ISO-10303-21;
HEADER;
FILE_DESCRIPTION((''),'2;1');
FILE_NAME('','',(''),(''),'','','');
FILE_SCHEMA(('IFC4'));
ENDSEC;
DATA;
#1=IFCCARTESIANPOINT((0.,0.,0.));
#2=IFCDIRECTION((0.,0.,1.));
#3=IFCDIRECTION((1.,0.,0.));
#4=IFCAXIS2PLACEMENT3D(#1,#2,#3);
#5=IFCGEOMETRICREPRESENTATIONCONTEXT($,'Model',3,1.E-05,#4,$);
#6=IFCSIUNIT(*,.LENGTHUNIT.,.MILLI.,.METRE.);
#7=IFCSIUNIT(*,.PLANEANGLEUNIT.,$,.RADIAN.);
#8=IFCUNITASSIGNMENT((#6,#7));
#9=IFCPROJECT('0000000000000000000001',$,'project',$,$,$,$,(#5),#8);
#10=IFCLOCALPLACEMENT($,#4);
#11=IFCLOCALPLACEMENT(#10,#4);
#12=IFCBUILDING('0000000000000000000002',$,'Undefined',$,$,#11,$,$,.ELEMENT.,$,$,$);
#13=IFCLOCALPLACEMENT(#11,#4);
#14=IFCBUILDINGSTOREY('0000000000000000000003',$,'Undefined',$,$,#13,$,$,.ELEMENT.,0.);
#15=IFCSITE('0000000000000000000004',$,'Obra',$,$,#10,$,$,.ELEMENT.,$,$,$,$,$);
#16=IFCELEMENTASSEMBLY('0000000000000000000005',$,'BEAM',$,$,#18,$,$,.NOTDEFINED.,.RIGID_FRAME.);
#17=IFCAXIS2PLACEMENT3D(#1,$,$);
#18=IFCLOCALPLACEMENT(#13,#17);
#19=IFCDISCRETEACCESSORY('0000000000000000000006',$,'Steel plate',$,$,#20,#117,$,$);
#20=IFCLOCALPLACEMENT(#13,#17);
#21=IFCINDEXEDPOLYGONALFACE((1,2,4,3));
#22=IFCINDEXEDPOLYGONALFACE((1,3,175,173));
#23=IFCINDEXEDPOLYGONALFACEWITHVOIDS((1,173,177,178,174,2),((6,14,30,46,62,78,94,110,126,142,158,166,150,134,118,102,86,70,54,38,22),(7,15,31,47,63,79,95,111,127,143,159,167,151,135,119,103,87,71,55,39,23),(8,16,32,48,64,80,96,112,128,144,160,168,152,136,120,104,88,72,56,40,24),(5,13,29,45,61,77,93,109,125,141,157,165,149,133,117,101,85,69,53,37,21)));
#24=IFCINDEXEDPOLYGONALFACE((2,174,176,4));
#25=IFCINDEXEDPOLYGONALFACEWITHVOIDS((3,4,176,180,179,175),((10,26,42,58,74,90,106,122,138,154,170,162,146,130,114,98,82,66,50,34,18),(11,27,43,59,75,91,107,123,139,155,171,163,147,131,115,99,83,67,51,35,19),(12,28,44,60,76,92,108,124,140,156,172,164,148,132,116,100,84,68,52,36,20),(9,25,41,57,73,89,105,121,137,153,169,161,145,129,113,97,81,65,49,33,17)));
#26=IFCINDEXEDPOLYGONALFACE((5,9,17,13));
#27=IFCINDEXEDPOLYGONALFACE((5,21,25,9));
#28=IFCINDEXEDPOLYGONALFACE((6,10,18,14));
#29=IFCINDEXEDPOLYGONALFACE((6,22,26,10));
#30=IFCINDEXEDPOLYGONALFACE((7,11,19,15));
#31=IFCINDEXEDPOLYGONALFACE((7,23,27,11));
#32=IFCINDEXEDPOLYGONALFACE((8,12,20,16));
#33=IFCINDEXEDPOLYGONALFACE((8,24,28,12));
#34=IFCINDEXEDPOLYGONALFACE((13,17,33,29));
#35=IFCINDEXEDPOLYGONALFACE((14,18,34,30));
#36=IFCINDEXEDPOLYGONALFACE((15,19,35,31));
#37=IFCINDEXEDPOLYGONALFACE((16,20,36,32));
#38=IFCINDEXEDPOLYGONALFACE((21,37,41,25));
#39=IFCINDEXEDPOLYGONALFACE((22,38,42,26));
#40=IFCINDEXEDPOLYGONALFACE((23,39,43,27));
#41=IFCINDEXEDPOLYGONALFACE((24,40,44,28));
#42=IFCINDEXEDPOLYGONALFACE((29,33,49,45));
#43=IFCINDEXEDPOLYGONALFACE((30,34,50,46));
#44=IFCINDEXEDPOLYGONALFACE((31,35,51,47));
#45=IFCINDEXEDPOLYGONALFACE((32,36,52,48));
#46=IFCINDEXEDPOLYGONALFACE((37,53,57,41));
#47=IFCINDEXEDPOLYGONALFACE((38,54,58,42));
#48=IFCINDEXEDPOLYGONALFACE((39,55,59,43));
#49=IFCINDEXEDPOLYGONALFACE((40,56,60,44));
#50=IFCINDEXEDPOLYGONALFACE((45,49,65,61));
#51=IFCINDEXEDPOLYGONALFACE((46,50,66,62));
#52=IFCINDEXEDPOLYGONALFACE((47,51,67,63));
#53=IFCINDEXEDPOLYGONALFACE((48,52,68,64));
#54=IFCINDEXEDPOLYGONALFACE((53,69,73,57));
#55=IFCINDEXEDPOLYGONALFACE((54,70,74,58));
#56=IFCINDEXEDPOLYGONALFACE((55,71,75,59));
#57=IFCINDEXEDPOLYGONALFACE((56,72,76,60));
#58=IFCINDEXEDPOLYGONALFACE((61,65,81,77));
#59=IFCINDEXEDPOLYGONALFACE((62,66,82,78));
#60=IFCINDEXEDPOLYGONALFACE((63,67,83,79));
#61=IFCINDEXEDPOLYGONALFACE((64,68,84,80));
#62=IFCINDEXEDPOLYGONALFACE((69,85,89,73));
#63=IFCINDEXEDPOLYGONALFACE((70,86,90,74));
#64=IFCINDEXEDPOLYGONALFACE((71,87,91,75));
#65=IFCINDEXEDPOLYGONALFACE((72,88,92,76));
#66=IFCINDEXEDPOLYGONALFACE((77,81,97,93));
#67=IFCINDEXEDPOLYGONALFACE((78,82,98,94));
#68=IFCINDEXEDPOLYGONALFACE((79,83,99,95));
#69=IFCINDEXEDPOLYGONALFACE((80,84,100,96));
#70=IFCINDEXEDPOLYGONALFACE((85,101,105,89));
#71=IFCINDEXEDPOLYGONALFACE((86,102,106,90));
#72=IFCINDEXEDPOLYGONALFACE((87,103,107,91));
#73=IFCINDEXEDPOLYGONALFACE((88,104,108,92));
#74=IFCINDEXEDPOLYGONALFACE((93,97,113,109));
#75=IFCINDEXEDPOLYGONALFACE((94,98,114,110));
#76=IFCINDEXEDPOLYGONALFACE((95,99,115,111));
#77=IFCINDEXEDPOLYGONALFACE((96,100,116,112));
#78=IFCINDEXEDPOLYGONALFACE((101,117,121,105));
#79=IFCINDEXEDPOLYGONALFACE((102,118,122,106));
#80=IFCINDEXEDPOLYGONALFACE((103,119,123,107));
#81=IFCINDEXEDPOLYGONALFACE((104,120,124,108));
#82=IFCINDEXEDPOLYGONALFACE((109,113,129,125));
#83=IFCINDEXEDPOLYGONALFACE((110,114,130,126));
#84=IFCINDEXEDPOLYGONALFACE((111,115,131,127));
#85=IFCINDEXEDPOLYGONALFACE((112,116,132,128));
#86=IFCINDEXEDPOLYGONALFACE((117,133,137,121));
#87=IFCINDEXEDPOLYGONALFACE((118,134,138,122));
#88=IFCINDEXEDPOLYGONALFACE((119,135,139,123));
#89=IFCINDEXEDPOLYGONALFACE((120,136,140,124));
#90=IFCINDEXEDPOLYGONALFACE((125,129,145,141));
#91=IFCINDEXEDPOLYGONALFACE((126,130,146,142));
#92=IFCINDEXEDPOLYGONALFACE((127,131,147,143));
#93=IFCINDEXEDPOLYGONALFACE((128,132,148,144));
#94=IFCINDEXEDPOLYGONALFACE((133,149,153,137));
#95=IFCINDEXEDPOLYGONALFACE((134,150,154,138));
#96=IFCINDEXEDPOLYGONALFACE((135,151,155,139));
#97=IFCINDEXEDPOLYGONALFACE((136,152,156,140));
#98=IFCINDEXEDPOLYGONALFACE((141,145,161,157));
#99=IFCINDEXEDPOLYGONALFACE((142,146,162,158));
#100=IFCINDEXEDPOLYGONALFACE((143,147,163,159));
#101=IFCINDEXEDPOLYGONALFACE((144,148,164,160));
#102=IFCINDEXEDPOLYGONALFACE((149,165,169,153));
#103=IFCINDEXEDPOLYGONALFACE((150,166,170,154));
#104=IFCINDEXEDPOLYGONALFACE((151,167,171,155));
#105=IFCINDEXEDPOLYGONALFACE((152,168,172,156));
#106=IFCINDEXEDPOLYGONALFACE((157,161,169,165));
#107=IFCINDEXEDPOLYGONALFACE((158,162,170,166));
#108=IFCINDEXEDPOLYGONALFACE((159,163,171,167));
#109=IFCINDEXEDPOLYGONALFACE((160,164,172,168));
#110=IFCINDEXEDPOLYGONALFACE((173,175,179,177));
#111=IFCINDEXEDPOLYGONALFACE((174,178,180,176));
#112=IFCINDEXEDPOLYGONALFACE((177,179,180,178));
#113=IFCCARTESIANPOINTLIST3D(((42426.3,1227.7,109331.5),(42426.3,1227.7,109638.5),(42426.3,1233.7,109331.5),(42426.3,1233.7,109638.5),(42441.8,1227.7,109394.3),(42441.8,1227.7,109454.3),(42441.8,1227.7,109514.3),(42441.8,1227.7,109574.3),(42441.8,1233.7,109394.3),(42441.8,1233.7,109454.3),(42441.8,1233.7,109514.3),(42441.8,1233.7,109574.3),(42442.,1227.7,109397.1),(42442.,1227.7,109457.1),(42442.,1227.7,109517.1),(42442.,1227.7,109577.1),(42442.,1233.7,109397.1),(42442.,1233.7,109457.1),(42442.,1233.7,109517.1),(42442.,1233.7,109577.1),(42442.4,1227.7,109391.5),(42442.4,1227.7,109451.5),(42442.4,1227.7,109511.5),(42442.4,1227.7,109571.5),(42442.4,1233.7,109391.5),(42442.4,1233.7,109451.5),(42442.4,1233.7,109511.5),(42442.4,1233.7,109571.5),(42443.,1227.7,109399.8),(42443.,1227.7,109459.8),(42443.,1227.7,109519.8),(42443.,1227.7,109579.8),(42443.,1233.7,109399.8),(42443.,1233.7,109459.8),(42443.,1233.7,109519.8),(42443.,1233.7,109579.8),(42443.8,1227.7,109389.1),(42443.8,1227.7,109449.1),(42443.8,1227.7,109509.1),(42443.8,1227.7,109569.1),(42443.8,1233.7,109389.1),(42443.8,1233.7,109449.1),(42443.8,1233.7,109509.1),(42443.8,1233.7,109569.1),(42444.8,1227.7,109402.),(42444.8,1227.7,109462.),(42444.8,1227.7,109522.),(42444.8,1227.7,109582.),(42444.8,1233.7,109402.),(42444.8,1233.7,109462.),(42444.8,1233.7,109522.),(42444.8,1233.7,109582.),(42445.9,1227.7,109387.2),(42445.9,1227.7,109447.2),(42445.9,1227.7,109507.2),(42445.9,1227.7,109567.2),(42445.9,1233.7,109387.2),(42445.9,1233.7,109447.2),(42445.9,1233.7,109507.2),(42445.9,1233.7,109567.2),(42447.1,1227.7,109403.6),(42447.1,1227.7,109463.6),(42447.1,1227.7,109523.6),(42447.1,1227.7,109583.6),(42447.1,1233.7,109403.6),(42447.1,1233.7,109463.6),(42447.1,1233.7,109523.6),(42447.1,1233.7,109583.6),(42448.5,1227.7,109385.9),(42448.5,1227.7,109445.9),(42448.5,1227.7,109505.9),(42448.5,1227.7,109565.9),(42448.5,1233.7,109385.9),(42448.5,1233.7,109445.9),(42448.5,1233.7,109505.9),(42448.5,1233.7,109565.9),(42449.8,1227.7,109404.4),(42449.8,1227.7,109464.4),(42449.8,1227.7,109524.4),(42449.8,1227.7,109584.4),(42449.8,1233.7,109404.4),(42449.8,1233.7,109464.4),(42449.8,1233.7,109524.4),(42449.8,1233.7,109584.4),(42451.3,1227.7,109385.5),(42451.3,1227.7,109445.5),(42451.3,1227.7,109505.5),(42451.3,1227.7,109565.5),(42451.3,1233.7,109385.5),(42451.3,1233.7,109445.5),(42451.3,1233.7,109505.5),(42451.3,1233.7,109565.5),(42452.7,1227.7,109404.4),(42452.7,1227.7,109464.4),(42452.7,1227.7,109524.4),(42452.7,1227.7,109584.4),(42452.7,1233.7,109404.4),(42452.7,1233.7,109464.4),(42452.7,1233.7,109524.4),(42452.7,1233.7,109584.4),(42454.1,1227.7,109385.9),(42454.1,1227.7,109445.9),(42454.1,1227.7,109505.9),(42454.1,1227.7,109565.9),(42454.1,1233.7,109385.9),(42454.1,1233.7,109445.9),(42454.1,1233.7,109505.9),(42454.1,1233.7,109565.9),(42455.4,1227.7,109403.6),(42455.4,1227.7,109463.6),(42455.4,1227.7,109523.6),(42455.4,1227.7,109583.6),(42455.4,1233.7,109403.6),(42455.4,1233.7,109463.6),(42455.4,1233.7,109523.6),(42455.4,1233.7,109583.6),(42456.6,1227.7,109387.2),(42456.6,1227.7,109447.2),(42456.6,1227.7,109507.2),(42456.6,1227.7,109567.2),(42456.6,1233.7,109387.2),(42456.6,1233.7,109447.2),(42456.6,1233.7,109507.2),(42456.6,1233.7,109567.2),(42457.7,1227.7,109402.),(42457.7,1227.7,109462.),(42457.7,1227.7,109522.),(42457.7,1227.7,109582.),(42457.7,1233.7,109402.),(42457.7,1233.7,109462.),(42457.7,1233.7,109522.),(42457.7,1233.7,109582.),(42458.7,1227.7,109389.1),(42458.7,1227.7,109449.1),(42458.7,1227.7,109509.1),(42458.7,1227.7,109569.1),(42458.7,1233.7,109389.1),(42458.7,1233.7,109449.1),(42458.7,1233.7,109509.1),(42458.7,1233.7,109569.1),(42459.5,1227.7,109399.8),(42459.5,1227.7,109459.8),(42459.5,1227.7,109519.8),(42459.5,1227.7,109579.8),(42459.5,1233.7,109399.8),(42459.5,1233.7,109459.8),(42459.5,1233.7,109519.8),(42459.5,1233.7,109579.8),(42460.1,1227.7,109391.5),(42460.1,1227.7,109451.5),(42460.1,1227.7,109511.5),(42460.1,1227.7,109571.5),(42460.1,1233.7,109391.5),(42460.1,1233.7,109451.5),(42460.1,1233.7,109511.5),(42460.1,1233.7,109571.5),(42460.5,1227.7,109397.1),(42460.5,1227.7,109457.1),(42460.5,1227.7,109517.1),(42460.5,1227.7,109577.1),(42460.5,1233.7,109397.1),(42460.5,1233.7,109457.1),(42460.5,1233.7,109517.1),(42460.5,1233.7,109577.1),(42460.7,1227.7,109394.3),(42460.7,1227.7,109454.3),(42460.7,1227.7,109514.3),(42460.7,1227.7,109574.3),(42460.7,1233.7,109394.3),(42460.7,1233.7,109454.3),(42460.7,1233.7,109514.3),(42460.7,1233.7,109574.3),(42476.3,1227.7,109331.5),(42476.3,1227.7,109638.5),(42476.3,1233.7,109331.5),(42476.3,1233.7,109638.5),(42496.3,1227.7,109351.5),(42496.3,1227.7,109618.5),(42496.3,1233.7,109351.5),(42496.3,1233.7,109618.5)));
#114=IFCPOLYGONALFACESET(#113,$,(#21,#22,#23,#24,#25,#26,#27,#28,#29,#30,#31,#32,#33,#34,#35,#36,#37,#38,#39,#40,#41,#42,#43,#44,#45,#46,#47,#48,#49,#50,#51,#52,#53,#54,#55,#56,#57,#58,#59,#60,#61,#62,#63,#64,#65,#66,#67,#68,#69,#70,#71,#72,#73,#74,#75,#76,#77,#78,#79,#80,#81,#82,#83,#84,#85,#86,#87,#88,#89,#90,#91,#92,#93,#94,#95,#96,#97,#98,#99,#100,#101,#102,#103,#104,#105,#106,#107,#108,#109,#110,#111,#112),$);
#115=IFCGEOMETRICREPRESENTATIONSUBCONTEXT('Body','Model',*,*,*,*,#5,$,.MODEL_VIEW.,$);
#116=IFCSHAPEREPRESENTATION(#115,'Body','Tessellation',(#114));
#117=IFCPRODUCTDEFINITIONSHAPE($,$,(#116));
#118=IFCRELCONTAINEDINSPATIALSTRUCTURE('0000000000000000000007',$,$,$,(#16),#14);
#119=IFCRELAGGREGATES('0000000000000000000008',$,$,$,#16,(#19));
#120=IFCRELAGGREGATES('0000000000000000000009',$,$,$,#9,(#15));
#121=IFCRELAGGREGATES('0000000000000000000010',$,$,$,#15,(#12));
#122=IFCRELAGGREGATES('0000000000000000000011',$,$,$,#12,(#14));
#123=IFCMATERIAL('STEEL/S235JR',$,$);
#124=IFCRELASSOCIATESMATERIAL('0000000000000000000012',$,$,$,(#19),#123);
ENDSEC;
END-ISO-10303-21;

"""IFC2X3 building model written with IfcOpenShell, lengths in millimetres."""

from ifc_helpers import new_model, si_unit, frame, origin_with_axes, origin_2d_with_axis, place, context, subcontext, project, spatial, polyline, circle, outline, extrude, source, transform, mapped, material, element, aggregate, save


model = new_model("IFC2X3")

# Units and contexts
model_context = context("Model", 3, precision=1e-05, world=origin_with_axes())
body_context = subcontext(model_context, "Body", "Model", "MODEL_VIEW")
ifc_project = project(units=[si_unit("LENGTHUNIT", "METRE", prefix="MILLI"), si_unit("PLANEANGLEUNIT", "RADIAN")], contexts=[model_context])

# Site, building, storey
site_placement = place(None, origin_with_axes())
site = spatial("IfcSite", under=ifc_project, at=site_placement, Name="Obra", CompositionType="ELEMENT")
building_placement = place(site_placement, origin_with_axes())
building = spatial("IfcBuilding", under=site, at=building_placement, Name="Undefined", CompositionType="ELEMENT")
storey_placement = place(building_placement, origin_with_axes())
storey = spatial("IfcBuildingStorey", under=building, at=storey_placement, Name="Undefined", CompositionType="ELEMENT", Elevation=0.0)

# Element assembly, discrete accessory, opening
ifc_material = material(Name="STEEL/S235JR")
shared_shape = source(origin_with_axes(), body_context, "Body", "SweptSolid", [
    extrude(circle(Radius=9.5, at=origin_2d_with_axis()), frame((0.0, -9.8, 0.0), z_axis=(0.0, 1.0, 0.0), x_axis=(1.0, 0.0, 0.0)), (0.0, 0.0, 1.0), 6.2),
])
assembly_1_placement = place(storey_placement, origin_with_axes())
assembly_1 = element("IfcElementAssembly", 1, at=assembly_1_placement, inside=storey, Name="BEAM", AssemblyPlace="NOTDEFINED", PredefinedType="RIGID_FRAME")
discrete_accessory_1_placement = place(assembly_1_placement, frame((42426.3, 1230.7, 109331.5), z_axis=(0.0, -1.0, 0.0), x_axis=(1.0, 0.0, 0.0)))
discrete_accessory_1 = element("IfcDiscreteAccessory", 2, at=discrete_accessory_1_placement, material=ifc_material, Name="Steel plate", context=body_context, shape_type="SweptSolid", body=[
    extrude(outline(polyline([(0.0, 0.0), (50.0, 0.0), (70.0, 20.0), (70.0, 287.0), (50.0, 307.0), (0.0, 307.0), (0.0, 0.0)])), frame((0.0, 0.0, -3.0), z_axis=(0.0, 0.0, 1.0), x_axis=(1.0, 0.0, 0.0)), (0.0, 0.0, 1.0), 6.0),
])
opening_1_placement = place(assembly_1_placement, frame((42486.3, 1224.0, 109650.0), z_axis=(-1.0, 0.0, 0.0), x_axis=(0.0, 0.0, -1.0)))
element("IfcOpeningElement", 3, at=opening_1_placement, cuts=discrete_accessory_1, ObjectType="Opening", context=body_context, shape_type="MappedRepresentation", body=[
    mapped(shared_shape, transform((75.0, 0.0, 35.0))),
    mapped(shared_shape, transform((135.0, 0.0, 35.0))),
    mapped(shared_shape, transform((195.0, 0.0, 35.0))),
    mapped(shared_shape, transform((255.0, 0.0, 35.0))),
])
aggregate(assembly_1, [discrete_accessory_1])

save(model, "model.ifc")
